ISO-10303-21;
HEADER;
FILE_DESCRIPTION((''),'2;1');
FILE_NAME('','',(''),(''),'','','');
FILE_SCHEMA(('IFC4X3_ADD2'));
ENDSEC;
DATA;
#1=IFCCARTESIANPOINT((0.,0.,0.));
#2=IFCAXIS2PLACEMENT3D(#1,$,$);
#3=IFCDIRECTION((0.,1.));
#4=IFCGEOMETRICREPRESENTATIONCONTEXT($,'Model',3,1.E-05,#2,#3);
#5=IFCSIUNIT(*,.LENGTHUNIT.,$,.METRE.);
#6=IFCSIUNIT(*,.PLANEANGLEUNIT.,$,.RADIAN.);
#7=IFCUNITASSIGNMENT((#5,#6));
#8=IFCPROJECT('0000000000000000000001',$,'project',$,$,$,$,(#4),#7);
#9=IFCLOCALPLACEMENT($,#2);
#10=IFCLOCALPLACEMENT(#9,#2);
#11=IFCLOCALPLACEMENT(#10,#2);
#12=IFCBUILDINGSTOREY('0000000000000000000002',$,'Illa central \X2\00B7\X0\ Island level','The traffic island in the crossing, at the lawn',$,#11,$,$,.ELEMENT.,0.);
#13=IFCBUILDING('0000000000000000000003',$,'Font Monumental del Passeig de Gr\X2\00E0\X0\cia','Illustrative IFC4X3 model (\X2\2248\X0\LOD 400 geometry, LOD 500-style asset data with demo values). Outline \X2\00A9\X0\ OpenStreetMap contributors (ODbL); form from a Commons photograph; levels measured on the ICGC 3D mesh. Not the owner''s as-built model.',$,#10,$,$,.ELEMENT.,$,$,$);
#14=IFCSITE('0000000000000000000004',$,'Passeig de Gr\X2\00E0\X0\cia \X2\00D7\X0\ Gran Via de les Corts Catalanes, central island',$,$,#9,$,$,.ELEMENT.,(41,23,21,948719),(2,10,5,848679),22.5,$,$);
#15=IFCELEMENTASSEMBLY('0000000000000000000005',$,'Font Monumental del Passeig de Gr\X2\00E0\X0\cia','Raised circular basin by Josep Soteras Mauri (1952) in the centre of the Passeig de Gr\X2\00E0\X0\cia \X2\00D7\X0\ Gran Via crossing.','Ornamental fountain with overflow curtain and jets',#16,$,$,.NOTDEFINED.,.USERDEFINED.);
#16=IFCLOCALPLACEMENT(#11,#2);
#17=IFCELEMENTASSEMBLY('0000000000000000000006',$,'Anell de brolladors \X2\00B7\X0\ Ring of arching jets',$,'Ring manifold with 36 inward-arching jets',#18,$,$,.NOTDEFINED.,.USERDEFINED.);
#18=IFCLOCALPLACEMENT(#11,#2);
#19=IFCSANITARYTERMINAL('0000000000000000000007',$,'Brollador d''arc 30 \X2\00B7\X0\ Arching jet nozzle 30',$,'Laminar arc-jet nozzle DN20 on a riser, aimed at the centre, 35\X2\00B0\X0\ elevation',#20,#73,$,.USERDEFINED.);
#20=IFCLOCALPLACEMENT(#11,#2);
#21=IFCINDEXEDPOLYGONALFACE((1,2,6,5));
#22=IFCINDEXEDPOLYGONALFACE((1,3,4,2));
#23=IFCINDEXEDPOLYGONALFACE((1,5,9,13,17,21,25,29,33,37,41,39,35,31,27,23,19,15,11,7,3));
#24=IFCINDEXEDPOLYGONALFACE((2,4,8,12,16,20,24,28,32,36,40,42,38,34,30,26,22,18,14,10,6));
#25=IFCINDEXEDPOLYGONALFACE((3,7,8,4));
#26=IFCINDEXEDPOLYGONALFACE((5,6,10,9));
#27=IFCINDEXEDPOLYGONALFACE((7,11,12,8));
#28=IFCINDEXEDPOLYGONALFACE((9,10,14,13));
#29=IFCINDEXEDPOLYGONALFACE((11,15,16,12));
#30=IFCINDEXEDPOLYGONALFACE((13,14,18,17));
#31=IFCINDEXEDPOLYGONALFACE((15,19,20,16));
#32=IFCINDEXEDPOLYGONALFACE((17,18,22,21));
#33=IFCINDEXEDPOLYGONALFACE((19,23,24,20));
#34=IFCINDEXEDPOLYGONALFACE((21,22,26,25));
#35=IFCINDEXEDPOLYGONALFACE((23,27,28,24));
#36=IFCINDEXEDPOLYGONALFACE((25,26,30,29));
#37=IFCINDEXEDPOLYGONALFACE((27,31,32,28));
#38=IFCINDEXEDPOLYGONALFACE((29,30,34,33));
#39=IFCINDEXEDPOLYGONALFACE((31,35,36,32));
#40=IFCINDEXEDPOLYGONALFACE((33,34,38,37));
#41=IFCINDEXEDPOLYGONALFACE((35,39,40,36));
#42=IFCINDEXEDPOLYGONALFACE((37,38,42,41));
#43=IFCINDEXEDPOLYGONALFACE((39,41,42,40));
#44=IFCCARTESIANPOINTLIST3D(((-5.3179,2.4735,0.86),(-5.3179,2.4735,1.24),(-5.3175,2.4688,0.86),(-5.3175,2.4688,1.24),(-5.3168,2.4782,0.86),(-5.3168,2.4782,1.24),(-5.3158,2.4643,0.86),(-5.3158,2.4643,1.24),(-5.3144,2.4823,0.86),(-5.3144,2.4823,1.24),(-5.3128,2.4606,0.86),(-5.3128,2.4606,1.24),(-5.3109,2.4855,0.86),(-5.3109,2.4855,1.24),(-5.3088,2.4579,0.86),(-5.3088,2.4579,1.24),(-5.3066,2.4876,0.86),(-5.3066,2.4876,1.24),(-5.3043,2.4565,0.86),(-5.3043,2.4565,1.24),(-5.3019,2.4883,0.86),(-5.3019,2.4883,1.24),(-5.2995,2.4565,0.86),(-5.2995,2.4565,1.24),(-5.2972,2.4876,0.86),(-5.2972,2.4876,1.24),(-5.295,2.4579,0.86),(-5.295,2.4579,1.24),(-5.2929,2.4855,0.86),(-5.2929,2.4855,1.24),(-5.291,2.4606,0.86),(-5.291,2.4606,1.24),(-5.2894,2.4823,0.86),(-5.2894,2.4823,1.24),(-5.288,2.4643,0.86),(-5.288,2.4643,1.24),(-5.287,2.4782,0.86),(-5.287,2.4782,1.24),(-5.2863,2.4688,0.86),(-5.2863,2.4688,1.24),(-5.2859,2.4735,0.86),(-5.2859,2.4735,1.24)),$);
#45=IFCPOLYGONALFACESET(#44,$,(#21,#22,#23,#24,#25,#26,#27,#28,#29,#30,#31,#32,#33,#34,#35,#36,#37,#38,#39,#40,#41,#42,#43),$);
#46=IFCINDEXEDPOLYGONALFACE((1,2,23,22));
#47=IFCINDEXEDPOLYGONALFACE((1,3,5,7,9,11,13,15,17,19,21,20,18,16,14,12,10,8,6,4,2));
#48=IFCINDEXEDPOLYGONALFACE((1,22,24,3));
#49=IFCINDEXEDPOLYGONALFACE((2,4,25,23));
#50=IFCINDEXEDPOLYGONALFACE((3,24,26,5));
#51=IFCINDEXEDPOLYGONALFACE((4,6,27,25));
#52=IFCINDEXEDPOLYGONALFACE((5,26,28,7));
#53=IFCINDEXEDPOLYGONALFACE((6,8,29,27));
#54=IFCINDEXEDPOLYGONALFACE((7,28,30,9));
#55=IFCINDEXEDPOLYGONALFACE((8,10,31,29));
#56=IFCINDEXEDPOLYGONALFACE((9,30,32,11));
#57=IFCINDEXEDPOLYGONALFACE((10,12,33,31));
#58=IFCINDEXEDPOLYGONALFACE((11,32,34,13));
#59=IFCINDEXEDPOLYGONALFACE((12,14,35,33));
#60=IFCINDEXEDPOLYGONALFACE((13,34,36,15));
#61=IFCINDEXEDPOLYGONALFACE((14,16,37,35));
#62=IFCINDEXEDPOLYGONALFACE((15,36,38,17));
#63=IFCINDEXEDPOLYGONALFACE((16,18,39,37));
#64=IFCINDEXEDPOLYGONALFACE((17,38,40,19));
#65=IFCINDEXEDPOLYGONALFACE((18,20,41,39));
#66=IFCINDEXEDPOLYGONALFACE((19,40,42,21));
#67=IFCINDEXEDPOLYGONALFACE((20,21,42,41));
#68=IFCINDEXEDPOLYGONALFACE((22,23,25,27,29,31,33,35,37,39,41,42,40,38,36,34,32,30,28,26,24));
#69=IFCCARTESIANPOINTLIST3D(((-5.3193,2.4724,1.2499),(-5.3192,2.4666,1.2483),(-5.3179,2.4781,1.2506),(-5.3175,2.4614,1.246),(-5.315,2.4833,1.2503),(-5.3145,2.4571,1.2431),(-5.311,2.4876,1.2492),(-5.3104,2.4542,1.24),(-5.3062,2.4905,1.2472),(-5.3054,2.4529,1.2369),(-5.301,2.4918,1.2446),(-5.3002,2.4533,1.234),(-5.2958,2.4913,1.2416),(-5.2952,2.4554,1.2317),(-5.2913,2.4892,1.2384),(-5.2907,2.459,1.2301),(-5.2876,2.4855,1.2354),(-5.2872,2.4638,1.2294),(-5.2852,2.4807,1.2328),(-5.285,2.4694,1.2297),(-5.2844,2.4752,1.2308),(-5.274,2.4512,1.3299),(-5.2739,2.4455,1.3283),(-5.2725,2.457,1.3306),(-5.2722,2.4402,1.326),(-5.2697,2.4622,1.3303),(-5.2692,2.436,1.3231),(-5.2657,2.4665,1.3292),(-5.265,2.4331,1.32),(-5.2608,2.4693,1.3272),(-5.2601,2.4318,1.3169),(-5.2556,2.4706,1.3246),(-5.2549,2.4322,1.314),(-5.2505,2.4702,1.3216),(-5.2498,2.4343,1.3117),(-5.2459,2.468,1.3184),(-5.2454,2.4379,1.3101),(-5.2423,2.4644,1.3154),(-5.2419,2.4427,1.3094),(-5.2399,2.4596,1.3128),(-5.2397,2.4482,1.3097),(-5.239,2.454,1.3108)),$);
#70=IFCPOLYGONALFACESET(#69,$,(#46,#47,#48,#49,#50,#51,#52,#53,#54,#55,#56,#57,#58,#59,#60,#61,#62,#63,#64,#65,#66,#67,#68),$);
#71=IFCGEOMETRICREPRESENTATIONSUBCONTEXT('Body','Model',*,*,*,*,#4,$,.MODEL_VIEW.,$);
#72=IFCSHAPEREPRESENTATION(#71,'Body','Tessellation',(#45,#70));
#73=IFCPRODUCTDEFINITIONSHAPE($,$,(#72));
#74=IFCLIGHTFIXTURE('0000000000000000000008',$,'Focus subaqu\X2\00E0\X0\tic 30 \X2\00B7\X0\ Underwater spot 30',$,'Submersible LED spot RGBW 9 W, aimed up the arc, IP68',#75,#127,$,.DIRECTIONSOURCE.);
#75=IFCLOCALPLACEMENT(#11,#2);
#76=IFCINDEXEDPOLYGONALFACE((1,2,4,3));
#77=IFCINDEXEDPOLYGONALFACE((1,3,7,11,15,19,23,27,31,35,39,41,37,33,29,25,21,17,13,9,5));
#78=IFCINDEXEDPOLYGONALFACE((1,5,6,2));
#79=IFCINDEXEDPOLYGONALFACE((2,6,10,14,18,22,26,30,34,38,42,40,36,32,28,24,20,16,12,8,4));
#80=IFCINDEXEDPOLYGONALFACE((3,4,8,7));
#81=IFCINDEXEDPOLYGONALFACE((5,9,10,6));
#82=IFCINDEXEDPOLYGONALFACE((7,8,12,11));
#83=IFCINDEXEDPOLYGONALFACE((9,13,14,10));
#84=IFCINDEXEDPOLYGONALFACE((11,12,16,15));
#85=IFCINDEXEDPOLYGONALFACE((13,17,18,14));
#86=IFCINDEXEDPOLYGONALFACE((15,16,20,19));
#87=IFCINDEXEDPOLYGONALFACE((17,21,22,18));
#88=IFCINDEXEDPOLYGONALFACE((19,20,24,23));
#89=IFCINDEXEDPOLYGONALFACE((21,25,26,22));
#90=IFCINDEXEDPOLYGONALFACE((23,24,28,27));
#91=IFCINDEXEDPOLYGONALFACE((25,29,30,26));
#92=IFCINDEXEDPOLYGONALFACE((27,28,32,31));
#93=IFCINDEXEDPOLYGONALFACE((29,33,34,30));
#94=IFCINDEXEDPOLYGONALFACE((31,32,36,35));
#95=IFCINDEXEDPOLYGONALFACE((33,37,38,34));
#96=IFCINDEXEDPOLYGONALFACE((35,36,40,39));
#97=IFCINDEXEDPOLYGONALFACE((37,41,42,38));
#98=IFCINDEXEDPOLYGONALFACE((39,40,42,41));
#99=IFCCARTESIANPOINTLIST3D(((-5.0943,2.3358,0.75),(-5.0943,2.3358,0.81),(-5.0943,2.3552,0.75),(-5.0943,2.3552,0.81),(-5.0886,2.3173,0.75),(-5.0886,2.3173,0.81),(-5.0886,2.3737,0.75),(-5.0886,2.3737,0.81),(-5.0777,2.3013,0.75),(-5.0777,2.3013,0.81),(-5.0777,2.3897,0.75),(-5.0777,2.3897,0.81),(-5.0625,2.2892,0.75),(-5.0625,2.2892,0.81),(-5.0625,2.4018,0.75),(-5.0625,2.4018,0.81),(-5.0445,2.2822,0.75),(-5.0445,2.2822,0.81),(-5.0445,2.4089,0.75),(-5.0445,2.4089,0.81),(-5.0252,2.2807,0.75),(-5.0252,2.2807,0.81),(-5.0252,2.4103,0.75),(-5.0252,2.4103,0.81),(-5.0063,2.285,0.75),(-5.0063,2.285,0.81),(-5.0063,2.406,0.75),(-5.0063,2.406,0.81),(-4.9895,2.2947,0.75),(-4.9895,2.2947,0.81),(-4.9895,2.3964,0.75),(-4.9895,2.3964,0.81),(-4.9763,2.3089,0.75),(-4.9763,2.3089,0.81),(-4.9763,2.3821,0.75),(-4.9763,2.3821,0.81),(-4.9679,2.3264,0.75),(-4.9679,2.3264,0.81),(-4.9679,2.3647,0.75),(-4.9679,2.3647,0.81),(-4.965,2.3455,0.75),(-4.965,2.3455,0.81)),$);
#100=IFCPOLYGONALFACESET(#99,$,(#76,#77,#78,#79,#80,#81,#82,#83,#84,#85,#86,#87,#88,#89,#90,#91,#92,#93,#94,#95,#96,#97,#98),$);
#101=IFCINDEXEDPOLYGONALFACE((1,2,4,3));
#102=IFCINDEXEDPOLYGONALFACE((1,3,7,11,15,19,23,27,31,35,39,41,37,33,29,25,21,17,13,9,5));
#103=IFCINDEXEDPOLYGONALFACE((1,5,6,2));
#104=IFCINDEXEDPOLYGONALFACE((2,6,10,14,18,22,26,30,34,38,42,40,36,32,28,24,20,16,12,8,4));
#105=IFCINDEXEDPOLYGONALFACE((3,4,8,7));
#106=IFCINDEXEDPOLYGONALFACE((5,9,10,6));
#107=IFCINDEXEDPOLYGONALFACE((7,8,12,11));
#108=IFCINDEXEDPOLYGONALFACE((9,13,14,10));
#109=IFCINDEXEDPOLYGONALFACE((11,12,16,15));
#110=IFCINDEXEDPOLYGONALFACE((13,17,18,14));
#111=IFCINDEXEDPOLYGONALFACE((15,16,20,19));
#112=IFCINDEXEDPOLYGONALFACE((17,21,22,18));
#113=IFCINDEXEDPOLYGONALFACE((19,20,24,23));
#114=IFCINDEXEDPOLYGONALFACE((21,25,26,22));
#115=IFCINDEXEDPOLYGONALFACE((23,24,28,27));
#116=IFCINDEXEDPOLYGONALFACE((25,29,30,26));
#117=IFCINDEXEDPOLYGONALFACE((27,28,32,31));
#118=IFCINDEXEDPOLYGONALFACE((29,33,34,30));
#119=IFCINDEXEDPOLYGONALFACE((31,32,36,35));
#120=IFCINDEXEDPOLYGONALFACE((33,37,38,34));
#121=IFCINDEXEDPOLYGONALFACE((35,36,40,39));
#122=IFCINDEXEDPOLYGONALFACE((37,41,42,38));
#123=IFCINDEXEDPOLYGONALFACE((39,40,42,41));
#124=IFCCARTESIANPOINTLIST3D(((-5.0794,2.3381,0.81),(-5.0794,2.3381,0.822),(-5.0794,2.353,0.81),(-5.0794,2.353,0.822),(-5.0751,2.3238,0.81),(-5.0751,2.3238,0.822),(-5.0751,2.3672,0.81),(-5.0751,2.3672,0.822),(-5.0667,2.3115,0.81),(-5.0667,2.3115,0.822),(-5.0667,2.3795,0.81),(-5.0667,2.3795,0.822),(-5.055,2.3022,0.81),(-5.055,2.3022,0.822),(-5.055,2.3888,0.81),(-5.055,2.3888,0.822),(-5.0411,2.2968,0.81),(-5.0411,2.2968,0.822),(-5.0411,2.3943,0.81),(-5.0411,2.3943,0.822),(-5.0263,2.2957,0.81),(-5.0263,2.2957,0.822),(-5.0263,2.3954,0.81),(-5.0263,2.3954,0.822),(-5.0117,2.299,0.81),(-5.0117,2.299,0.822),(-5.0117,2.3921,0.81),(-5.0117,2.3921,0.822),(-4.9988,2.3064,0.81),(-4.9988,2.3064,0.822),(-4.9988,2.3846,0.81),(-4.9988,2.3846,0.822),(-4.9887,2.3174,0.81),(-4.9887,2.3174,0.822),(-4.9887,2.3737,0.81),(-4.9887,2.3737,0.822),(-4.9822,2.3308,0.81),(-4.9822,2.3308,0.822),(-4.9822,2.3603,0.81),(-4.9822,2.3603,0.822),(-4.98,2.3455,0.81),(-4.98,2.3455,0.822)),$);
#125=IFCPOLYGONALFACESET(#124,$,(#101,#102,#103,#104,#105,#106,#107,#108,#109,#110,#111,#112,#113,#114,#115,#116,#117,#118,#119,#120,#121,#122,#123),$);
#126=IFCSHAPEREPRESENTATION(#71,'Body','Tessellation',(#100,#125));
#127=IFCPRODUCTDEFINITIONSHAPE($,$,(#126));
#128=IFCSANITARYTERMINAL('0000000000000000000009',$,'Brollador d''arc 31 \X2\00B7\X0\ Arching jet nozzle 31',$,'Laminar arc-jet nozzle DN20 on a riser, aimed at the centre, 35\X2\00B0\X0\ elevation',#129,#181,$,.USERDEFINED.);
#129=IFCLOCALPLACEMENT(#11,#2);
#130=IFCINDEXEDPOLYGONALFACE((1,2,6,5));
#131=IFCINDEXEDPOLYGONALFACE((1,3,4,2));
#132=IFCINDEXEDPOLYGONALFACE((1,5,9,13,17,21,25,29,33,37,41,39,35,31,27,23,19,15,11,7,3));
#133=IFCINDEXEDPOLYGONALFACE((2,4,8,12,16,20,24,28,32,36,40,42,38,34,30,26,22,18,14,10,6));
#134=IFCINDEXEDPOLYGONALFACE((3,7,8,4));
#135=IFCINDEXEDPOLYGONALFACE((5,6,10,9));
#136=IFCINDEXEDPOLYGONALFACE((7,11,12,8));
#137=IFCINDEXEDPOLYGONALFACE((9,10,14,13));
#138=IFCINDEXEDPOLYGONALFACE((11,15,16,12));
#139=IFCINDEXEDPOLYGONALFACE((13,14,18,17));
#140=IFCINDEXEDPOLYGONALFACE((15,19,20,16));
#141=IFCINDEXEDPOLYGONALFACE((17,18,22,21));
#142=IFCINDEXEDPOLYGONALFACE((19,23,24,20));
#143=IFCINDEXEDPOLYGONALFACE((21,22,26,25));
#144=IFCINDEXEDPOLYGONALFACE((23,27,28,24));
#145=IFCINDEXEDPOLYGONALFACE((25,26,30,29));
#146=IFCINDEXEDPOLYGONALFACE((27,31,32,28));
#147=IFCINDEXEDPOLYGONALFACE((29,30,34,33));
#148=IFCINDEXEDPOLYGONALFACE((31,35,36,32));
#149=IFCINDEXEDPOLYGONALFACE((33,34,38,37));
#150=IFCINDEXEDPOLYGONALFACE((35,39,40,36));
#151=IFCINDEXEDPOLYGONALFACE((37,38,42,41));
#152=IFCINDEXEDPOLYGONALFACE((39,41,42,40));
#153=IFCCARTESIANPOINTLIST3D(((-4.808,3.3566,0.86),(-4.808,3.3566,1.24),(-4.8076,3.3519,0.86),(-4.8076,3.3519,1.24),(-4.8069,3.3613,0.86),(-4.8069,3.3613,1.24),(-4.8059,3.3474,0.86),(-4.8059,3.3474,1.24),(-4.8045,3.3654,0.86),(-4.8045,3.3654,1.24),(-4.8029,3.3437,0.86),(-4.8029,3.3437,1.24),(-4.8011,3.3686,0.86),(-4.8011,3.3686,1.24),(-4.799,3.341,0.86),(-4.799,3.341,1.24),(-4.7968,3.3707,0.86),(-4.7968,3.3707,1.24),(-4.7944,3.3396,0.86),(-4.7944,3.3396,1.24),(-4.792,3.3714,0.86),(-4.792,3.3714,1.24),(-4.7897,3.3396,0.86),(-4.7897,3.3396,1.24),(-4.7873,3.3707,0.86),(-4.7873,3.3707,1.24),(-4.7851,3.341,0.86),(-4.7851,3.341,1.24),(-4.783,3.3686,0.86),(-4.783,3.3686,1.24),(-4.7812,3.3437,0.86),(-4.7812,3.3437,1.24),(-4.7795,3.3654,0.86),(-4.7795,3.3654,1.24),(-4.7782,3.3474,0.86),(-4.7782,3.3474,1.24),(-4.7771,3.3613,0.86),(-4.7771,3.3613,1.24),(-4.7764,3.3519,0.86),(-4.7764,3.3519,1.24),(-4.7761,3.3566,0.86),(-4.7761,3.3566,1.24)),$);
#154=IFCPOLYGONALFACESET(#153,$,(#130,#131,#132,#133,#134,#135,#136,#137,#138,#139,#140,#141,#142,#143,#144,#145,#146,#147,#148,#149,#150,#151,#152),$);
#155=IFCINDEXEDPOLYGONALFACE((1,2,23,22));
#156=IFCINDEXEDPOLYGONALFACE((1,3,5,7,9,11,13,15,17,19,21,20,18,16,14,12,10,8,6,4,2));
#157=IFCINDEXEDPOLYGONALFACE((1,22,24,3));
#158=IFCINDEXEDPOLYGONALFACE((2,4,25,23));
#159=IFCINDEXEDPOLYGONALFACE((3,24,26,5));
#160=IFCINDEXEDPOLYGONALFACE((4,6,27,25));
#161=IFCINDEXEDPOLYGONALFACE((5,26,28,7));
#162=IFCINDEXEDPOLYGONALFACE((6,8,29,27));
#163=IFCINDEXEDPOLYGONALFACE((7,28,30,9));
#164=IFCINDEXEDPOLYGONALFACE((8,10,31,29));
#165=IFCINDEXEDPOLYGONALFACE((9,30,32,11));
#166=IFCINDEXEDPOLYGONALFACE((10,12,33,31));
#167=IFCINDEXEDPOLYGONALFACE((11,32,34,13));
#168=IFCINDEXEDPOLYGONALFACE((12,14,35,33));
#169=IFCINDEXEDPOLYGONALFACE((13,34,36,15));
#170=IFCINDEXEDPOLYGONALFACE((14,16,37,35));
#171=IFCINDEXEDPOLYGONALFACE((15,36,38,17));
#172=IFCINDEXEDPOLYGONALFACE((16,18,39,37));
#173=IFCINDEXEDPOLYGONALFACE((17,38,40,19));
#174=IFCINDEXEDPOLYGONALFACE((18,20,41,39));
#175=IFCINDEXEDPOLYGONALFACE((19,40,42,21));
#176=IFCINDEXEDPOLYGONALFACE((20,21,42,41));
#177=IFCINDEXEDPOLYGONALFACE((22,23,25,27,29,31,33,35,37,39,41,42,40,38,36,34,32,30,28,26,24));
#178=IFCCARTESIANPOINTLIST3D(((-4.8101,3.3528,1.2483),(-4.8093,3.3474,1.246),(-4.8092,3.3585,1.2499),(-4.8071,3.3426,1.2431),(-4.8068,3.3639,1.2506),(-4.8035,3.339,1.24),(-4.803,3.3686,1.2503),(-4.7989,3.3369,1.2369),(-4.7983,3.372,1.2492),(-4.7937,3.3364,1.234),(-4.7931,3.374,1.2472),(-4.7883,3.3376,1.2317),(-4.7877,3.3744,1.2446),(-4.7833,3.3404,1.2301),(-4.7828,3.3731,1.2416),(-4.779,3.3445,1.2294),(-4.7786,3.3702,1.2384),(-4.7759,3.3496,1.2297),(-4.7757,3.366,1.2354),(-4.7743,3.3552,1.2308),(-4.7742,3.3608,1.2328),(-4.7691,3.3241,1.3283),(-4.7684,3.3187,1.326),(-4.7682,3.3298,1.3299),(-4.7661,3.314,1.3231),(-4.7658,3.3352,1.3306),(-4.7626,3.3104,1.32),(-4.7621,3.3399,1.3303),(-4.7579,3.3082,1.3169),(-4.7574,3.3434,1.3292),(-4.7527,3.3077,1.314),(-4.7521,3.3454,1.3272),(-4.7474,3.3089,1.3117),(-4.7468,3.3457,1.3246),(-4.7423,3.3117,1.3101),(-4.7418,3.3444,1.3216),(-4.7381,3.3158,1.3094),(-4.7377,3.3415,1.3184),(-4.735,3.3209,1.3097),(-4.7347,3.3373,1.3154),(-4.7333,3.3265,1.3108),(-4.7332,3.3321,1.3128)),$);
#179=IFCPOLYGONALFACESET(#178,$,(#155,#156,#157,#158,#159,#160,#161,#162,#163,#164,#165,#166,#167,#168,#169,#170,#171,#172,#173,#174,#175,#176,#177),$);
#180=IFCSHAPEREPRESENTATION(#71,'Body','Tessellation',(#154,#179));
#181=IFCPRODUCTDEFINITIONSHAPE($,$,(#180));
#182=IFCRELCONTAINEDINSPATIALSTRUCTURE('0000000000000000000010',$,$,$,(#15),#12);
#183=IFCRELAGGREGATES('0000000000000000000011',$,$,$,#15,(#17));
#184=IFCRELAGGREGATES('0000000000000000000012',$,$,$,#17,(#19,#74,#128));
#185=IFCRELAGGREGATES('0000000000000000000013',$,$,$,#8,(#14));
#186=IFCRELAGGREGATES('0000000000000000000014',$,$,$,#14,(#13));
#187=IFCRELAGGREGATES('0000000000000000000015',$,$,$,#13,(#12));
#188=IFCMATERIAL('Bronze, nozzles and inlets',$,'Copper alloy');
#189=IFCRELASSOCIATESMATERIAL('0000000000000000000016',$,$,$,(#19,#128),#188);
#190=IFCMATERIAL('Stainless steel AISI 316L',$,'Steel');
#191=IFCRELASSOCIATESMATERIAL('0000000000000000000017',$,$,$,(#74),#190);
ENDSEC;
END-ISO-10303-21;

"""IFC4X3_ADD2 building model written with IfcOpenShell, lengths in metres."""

from ifc_helpers import new_model, si_unit, direction, frame, origin, origin_2d_with_axis, place, context, subcontext, project, spatial, circle, extrude, material, element, aggregate, save


model = new_model("IFC4X3_ADD2")

# Units and contexts
model_context = context("Model", 3, precision=1e-05, world=origin(), true_north=direction((0.0, 1.0)))
body_context = subcontext(model_context, "Body", "Model", "MODEL_VIEW")
ifc_project = project(units=[si_unit("LENGTHUNIT", "METRE"), si_unit("PLANEANGLEUNIT", "RADIAN")], contexts=[model_context])

# Site, building, storey
site_placement = place(None, origin())
site = spatial("IfcSite", under=ifc_project, at=site_placement, Name="Passeig de Gràcia × Gran Via de les Corts Catalanes, central island", CompositionType="ELEMENT", RefLatitude=(41, 23, 21, 948719), RefLongitude=(2, 10, 5, 848679), RefElevation=22.5)
building_placement = place(site_placement, origin())
building = spatial("IfcBuilding", under=site, at=building_placement, Name="Font Monumental del Passeig de Gràcia", Description="Illustrative IFC4X3 model (≈LOD 400 geometry, LOD 500-style asset data with demo values). Outline © OpenStreetMap contributors (ODbL); form from a Commons photograph; levels measured on the ICGC 3D mesh. Not the owner's as-built model.", CompositionType="ELEMENT")
storey_placement = place(building_placement, origin())
storey = spatial("IfcBuildingStorey", under=building, at=storey_placement, Name="Illa central · Island level", Description="The traffic island in the crossing, at the lawn", CompositionType="ELEMENT", Elevation=0.0)

# Element assemblies, sanitary terminals, light fixture
assembly_1_placement = place(building_placement, origin())
assembly_1 = element("IfcElementAssembly", 1, at=assembly_1_placement, inside=storey, Name="Font Monumental del Passeig de Gràcia", Description="Raised circular basin by Josep Soteras Mauri (1952) in the centre of the Passeig de Gràcia × Gran Via crossing.", ObjectType="Ornamental fountain with overflow curtain and jets", AssemblyPlace="NOTDEFINED", PredefinedType="USERDEFINED")
assembly_2_placement = place(building_placement, origin())
assembly_2 = element("IfcElementAssembly", 2, at=assembly_2_placement, Name="Anell de brolladors · Ring of arching jets", ObjectType="Ring manifold with 36 inward-arching jets", AssemblyPlace="NOTDEFINED", PredefinedType="USERDEFINED")
aggregate(assembly_1, [assembly_2])
ifc_material_1 = material(Name="Stainless steel AISI 316L", Category="Steel")
ifc_material_2 = material(Name="Bronze, nozzles and inlets", Category="Copper alloy")
sanitary_terminal_1_placement = place(building_placement, origin())
sanitary_terminal_1 = element("IfcSanitaryTerminal", 3, at=sanitary_terminal_1_placement, material=ifc_material_2, Name="Brollador d'arc 30 · Arching jet nozzle 30", ObjectType="Laminar arc-jet nozzle DN20 on a riser, aimed at the centre, 35° elevation", PredefinedType="USERDEFINED", context=body_context, shape_type="SweptSolid", body=[
    extrude(circle(Radius=0.016, at=origin_2d_with_axis()), frame((-5.3019, 2.4723, 0.86), z_axis=(0.0, 0.0, 1.0), x_axis=(0.0, 1.0, 0.0)), (0.0, 0.0, 1.0), 0.38),
    extrude(circle(Radius=0.02, at=origin_2d_with_axis()), frame((-5.3019, 2.4723, 1.24), z_axis=(0.480342, -0.223987, 0.847998), x_axis=(-0.422618, -0.906308, 0.0)), (0.0, 0.0, 1.0), 0.0943),
])
light_fixture_1_placement = place(building_placement, origin())
light_fixture_1 = element("IfcLightFixture", 4, at=light_fixture_1_placement, material=ifc_material_1, Name="Focus subaquàtic 30 · Underwater spot 30", ObjectType="Submersible LED spot RGBW 9 W, aimed up the arc, IP68", PredefinedType="DIRECTIONSOURCE", context=body_context, shape_type="SweptSolid", body=[
    extrude(circle(Radius=0.065, at=origin_2d_with_axis()), frame((-5.03, 2.3455, 0.75)), (0.0, 0.0, 1.0), 0.06),
    extrude(circle(Radius=0.05, at=origin_2d_with_axis()), frame((-5.03, 2.3455, 0.81)), (0.0, 0.0, 1.0), 0.012),
])
sanitary_terminal_2_placement = place(building_placement, origin())
sanitary_terminal_2 = element("IfcSanitaryTerminal", 5, at=sanitary_terminal_2_placement, material=ifc_material_2, Name="Brollador d'arc 31 · Arching jet nozzle 31", ObjectType="Laminar arc-jet nozzle DN20 on a riser, aimed at the centre, 35° elevation", PredefinedType="USERDEFINED", context=body_context, shape_type="SweptSolid", body=[
    extrude(circle(Radius=0.016, at=origin_2d_with_axis()), frame((-4.792, 3.3554, 0.86), z_axis=(0.0, 0.0, 1.0), x_axis=(0.0, 1.0, 0.0)), (0.0, 0.0, 1.0), 0.38),
    extrude(circle(Radius=0.02, at=origin_2d_with_axis()), frame((-4.792, 3.3554, 1.24), z_axis=(0.43415, -0.303995, 0.847998), x_axis=(-0.573576, -0.819152, 0.0)), (0.0, 0.0, 1.0), 0.0943),
])
aggregate(assembly_2, [sanitary_terminal_1, light_fixture_1, sanitary_terminal_2])

save(model, "model.ifc")
